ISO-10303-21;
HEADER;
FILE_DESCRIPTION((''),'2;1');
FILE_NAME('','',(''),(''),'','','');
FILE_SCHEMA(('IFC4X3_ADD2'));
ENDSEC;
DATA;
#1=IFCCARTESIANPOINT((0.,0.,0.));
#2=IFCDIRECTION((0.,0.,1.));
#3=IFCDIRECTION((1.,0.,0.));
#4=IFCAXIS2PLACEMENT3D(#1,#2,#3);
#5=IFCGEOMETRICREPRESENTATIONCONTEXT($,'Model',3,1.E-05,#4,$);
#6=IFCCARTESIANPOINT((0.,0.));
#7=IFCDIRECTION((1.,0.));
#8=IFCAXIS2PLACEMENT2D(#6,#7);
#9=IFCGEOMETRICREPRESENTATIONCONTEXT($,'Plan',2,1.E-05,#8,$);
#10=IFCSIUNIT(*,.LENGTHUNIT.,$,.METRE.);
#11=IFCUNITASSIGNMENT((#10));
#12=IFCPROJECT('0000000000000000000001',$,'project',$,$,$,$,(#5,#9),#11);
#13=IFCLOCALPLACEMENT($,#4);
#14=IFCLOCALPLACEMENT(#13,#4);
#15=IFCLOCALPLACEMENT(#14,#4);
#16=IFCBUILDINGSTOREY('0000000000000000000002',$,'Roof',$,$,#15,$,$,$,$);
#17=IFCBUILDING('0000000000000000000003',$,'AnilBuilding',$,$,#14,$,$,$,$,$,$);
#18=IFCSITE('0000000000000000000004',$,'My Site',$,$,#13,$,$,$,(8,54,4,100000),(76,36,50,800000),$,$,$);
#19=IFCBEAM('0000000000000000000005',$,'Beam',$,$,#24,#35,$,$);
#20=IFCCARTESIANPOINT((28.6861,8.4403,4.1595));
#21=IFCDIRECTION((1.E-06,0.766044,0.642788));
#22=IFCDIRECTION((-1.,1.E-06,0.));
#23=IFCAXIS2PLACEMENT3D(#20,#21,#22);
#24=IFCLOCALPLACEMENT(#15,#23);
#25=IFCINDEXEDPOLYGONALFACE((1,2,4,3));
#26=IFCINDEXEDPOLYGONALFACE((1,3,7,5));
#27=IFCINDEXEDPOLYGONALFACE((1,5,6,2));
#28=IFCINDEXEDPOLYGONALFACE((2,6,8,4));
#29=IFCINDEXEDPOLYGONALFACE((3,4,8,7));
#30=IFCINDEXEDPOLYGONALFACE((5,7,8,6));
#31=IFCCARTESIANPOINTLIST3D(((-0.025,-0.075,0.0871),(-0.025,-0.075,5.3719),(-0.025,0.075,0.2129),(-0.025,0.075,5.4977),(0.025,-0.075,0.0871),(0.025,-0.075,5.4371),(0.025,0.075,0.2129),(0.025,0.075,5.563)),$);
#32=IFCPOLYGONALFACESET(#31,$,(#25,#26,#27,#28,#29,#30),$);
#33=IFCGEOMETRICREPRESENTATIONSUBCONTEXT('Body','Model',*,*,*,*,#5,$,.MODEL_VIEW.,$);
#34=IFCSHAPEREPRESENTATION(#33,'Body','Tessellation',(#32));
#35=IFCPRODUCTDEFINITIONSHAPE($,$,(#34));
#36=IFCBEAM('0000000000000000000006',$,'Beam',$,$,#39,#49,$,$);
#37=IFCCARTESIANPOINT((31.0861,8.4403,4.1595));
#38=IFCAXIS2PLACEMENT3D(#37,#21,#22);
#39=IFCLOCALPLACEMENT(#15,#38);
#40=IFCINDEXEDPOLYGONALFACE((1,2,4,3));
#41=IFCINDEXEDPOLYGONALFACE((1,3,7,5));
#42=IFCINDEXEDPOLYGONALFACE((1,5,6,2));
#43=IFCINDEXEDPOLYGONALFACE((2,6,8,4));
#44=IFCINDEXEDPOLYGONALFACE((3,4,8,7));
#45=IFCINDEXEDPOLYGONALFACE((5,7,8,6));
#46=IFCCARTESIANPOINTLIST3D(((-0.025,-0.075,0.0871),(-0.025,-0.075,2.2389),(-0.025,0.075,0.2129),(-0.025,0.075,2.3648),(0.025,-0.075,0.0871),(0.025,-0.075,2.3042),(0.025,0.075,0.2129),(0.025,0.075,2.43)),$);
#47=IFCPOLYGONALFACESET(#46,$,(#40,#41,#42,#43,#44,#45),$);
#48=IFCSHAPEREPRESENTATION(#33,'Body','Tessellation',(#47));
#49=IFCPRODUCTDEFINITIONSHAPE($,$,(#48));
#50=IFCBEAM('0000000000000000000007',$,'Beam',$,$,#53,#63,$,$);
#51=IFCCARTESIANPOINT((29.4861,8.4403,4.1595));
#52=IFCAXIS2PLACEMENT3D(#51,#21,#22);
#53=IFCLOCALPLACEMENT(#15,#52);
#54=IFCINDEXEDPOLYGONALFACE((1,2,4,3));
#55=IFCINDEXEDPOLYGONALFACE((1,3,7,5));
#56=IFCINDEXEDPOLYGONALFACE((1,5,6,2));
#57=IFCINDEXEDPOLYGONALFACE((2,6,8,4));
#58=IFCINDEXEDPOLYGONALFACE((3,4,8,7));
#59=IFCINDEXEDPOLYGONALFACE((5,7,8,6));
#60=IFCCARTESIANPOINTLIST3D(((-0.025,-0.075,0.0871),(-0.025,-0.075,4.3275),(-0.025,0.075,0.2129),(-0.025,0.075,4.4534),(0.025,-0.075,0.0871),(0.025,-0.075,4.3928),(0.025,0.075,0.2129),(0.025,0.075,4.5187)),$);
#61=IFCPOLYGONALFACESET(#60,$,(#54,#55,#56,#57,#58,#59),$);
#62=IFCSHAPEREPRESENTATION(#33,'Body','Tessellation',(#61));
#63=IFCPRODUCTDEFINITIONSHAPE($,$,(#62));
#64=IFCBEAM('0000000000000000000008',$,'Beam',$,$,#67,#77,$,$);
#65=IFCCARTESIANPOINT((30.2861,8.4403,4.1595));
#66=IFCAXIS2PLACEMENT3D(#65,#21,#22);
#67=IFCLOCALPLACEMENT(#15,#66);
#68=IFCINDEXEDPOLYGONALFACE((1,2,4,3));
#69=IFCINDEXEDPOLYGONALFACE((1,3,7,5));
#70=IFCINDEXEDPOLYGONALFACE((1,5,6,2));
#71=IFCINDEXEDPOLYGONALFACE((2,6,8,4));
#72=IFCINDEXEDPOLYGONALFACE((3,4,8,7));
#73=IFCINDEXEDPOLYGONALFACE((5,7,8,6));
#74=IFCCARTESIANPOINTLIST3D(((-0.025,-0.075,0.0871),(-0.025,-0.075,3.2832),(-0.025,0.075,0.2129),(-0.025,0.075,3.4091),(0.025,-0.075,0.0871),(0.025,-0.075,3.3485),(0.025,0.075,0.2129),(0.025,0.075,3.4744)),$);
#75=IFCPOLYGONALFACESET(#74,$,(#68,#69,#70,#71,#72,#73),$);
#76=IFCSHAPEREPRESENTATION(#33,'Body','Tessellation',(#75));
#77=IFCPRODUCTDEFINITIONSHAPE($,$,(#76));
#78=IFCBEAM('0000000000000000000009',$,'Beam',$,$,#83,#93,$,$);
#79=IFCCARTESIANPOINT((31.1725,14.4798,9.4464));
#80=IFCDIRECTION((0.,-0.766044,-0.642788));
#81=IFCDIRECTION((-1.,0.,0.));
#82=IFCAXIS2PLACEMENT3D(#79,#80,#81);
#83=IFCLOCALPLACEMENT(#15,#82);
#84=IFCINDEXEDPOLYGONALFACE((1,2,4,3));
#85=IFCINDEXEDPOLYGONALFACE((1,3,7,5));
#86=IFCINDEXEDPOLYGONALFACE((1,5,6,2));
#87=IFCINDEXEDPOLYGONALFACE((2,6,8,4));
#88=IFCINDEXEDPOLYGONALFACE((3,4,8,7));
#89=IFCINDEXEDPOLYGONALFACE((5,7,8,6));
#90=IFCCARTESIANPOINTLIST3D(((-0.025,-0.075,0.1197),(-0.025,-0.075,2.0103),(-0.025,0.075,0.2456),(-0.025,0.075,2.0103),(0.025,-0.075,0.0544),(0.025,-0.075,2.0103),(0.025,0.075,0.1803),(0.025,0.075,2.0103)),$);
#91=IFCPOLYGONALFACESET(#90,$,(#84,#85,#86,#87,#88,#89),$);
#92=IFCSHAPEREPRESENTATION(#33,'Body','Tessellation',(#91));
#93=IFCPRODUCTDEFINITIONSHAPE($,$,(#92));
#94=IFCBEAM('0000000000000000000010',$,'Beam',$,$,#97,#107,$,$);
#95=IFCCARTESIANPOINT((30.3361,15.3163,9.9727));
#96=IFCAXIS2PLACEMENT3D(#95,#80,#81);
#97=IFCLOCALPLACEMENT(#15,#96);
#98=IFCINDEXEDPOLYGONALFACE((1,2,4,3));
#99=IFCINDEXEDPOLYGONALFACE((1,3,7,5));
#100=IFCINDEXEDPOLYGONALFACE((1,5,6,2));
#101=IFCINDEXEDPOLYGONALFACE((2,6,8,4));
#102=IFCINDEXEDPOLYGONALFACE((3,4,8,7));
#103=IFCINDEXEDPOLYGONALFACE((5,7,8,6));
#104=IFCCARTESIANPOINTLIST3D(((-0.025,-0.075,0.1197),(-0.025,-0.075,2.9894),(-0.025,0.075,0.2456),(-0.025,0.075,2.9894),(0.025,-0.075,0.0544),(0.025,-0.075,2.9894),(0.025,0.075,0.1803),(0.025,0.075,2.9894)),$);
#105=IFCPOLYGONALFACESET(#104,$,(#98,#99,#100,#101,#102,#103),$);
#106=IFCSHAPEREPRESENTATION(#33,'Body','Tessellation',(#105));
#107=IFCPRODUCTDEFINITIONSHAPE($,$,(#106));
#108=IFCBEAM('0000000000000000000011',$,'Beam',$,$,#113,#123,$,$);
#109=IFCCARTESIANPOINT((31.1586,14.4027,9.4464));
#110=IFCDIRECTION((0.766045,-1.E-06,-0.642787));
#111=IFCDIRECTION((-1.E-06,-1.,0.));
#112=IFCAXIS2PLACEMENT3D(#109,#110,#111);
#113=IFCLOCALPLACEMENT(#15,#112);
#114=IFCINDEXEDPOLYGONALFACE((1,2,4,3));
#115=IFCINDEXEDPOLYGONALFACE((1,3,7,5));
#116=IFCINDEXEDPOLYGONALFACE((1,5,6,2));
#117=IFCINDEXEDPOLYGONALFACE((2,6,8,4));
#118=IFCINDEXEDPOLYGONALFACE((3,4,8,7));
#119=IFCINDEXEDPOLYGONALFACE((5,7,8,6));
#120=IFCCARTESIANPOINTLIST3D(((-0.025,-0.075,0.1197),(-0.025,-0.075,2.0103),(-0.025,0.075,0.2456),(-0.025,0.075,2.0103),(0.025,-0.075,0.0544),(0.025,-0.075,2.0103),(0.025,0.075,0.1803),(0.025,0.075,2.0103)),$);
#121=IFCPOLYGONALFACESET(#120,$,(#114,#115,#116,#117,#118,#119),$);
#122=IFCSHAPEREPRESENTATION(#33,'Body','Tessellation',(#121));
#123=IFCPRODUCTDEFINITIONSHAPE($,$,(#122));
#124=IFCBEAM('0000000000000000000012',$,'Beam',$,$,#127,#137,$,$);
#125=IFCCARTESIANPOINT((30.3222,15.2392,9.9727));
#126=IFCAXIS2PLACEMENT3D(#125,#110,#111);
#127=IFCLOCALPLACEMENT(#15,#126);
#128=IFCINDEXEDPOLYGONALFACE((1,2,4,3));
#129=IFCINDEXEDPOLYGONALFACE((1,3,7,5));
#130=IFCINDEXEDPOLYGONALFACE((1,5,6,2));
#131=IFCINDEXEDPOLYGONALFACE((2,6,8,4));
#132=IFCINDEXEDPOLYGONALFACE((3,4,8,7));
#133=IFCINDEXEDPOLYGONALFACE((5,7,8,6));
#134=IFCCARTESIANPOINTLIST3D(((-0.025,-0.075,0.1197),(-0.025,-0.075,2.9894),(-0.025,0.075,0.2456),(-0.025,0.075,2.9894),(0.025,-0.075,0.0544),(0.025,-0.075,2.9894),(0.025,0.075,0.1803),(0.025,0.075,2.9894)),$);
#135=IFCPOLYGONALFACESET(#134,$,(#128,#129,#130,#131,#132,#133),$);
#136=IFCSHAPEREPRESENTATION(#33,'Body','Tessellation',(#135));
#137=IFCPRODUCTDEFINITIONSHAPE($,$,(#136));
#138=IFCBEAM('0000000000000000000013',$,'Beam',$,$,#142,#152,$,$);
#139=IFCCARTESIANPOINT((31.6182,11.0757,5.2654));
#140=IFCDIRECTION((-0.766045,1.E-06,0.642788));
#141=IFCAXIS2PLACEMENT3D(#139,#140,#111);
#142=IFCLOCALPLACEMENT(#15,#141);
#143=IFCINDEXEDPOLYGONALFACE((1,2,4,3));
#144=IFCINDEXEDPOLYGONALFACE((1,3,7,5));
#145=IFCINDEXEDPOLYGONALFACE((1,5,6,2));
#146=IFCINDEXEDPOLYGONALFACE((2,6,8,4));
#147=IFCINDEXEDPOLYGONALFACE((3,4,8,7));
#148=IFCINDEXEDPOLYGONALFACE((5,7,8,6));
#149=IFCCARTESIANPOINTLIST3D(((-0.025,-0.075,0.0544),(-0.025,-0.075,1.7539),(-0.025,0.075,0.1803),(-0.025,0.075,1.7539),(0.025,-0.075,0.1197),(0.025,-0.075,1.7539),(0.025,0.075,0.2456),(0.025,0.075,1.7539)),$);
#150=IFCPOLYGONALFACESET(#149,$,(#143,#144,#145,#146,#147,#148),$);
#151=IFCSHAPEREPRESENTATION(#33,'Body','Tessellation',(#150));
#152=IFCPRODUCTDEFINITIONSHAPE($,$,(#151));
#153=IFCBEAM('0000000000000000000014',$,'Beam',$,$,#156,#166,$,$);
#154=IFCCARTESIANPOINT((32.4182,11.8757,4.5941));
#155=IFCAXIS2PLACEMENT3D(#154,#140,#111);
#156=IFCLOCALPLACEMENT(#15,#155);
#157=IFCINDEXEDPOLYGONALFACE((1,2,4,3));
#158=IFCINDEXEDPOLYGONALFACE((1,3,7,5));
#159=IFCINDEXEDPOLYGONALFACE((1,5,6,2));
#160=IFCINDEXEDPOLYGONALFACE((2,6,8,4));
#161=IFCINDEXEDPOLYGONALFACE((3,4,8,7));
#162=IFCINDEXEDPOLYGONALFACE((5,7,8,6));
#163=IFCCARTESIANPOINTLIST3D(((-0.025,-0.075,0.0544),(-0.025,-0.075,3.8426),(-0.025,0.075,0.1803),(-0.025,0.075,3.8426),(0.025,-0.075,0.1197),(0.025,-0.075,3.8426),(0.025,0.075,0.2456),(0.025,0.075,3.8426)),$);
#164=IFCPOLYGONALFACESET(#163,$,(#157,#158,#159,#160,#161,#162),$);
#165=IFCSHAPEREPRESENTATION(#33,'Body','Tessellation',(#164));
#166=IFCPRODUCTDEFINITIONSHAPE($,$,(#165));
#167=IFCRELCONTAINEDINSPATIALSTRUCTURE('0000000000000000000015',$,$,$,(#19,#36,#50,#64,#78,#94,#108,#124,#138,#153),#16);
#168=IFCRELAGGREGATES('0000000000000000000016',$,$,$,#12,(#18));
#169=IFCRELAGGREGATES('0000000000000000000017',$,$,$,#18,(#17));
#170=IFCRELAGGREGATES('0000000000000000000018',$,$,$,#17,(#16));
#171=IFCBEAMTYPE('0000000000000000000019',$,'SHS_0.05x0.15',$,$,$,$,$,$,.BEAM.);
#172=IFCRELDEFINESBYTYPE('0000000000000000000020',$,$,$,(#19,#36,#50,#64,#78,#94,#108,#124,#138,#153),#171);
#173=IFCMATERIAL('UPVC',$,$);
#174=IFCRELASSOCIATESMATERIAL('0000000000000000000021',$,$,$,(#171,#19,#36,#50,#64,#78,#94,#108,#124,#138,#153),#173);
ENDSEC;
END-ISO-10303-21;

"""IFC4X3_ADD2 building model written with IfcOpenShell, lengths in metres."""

from ifc_helpers import new_model, si_unit, frame, origin_with_axes, origin_2d_with_axis, place, context, subcontext, project, spatial, indexed_curve, outline, extrude, clip, halfspace, material, material_profile, profile_set, profile_usage, type_object, element, save


model = new_model("IFC4X3_ADD2")

# Units and contexts
model_context = context("Model", 3, precision=1e-05, world=origin_with_axes())
plan_context = context("Plan", 2, precision=1e-05, world=origin_2d_with_axis())
body_context_1 = subcontext(model_context, "Body", "Model", "MODEL_VIEW")
ifc_project = project(units=[si_unit("LENGTHUNIT", "METRE")], contexts=[model_context, plan_context])

# Site, building, storey
site_placement = place(None, origin_with_axes())
site = spatial("IfcSite", under=ifc_project, at=site_placement, Name="My Site", RefLatitude=(8, 54, 4, 100000), RefLongitude=(76, 36, 50, 800000))
building_placement = place(site_placement, origin_with_axes())
building = spatial("IfcBuilding", under=site, at=building_placement, Name="AnilBuilding")
storey_placement = place(building_placement, origin_with_axes())
storey = spatial("IfcBuildingStorey", under=building, at=storey_placement, Name="Roof")

# Beams
ifc_material_1 = material(Name="UPVC")
ifc_material_profile_1 = material_profile(ifc_material_1, outline(indexed_curve([(-0.025, 0.075), (0.025, 0.075), (0.025, -0.075), (-0.025, -0.075), (-0.025, 0.075)])))
ifc_profile_set_1 = profile_set([ifc_material_profile_1])
beam_type = type_object("IfcBeamType", Name="SHS_0.05x0.15", PredefinedType="BEAM", material=ifc_profile_set_1)
ifc_profile_usage_1 = profile_usage(ifc_profile_set_1, cardinal=5)
beam_1_placement = place(storey_placement, frame((28.6861, 8.4403, 4.1595), z_axis=(0.000001, 0.766044, 0.642788), x_axis=(-1.0, 0.000001, 0.0)))
element("IfcBeam", 1, at=beam_1_placement, inside=storey, type_object=beam_type, material=ifc_profile_usage_1, Name="Beam", context=body_context_1, shape_type="Clipping", body=[
    clip(clip(extrude(outline(indexed_curve([(-0.025, 0.075), (0.025, 0.075), (0.025, -0.075), (-0.025, -0.075), (-0.025, 0.075)])), origin_with_axes(), (0.0, 0.0, 1.0), 5.6174), halfspace(frame((12.9745, -0.0793, 0.0835), z_axis=(0.0, 0.642787, -0.766045), x_axis=(1.0, -0.000001, 0.0)), False)), halfspace(frame((3.131, -0.031, 9.5286), z_axis=(-0.707106, -0.45452, 0.541676), x_axis=(-0.540717, 0.841204, 0.0)), False)),
])
ifc_profile_usage_2 = profile_usage(ifc_profile_set_1, cardinal=5)
beam_2_placement = place(storey_placement, frame((31.0861, 8.4403, 4.1595), z_axis=(0.000001, 0.766044, 0.642788), x_axis=(-1.0, 0.000001, 0.0)))
element("IfcBeam", 2, at=beam_2_placement, inside=storey, type_object=beam_type, material=ifc_profile_usage_2, Name="Beam", context=body_context_1, shape_type="Clipping", body=[
    clip(clip(extrude(outline(indexed_curve([(-0.025, 0.075), (0.025, 0.075), (0.025, -0.075), (-0.025, -0.075), (-0.025, 0.075)])), origin_with_axes(), (0.0, 0.0, 1.0), 2.4845), halfspace(frame((15.3745, -0.0793, 0.0835), z_axis=(0.0, 0.642787, -0.766045), x_axis=(1.0, -0.000001, 0.0)), False)), halfspace(frame((5.531, -0.031, 9.5286), z_axis=(-0.707106, -0.45452, 0.541676), x_axis=(-0.540717, 0.841204, 0.0)), False)),
])
ifc_profile_usage_3 = profile_usage(ifc_profile_set_1, cardinal=5)
beam_3_placement = place(storey_placement, frame((29.4861, 8.4403, 4.1595), z_axis=(0.000001, 0.766044, 0.642788), x_axis=(-1.0, 0.000001, 0.0)))
element("IfcBeam", 3, at=beam_3_placement, inside=storey, type_object=beam_type, material=ifc_profile_usage_3, Name="Beam", context=body_context_1, shape_type="Clipping", body=[
    clip(clip(extrude(outline(indexed_curve([(-0.025, 0.075), (0.025, 0.075), (0.025, -0.075), (-0.025, -0.075), (-0.025, 0.075)])), origin_with_axes(), (0.0, 0.0, 1.0), 4.5731), halfspace(frame((13.7745, -0.0793, 0.0835), z_axis=(0.0, 0.642787, -0.766045), x_axis=(1.0, -0.000001, 0.0)), False)), halfspace(frame((3.931, -0.031, 9.5286), z_axis=(-0.707106, -0.45452, 0.541676), x_axis=(-0.540717, 0.841204, 0.0)), False)),
])
ifc_profile_usage_4 = profile_usage(ifc_profile_set_1, cardinal=5)
beam_4_placement = place(storey_placement, frame((30.2861, 8.4403, 4.1595), z_axis=(0.000001, 0.766044, 0.642788), x_axis=(-1.0, 0.000001, 0.0)))
element("IfcBeam", 4, at=beam_4_placement, inside=storey, type_object=beam_type, material=ifc_profile_usage_4, Name="Beam", context=body_context_1, shape_type="Clipping", body=[
    clip(clip(extrude(outline(indexed_curve([(-0.025, 0.075), (0.025, 0.075), (0.025, -0.075), (-0.025, -0.075), (-0.025, 0.075)])), origin_with_axes(), (0.0, 0.0, 1.0), 3.5288), halfspace(frame((14.5745, -0.0793, 0.0835), z_axis=(0.0, 0.642787, -0.766045), x_axis=(1.0, -0.000001, 0.0)), False)), halfspace(frame((4.731, -0.031, 9.5286), z_axis=(-0.707106, -0.45452, 0.541676), x_axis=(-0.540717, 0.841204, 0.0)), False)),
])
ifc_profile_usage_5 = profile_usage(ifc_profile_set_1, cardinal=5)
beam_5_placement = place(storey_placement, frame((31.1725, 14.4798, 9.4464), z_axis=(0.0, -0.766044, -0.642788), x_axis=(-1.0, 0.0, 0.0)))
element("IfcBeam", 5, at=beam_5_placement, inside=storey, type_object=beam_type, material=ifc_profile_usage_5, Name="Beam", context=body_context_1, shape_type="Clipping", body=[
    clip(extrude(outline(indexed_curve([(-0.025, 0.075), (0.025, 0.075), (0.025, -0.075), (-0.025, -0.075), (-0.025, 0.075)])), origin_with_axes(), (0.0, 0.0, 1.0), 2.0103), halfspace(frame((1.3254, 0.1182, -1.4809), z_axis=(-0.707106, 0.45452, -0.541676), x_axis=(0.540717, 0.841205, 0.0)), False)),
])
ifc_profile_usage_6 = profile_usage(ifc_profile_set_1, cardinal=5)
beam_6_placement = place(storey_placement, frame((30.3361, 15.3163, 9.9727), z_axis=(0.0, -0.766044, -0.642788), x_axis=(-1.0, 0.0, 0.0)))
element("IfcBeam", 6, at=beam_6_placement, inside=storey, type_object=beam_type, material=ifc_profile_usage_6, Name="Beam", context=body_context_1, shape_type="Clipping", body=[
    clip(extrude(outline(indexed_curve([(-0.025, 0.075), (0.025, 0.075), (0.025, -0.075), (-0.025, -0.075), (-0.025, 0.075)])), origin_with_axes(), (0.0, 0.0, 1.0), 2.9894), halfspace(frame((0.4889, -0.0163, -0.5019), z_axis=(-0.707106, 0.45452, -0.541676), x_axis=(0.540717, 0.841205, 0.0)), False)),
])
ifc_profile_usage_7 = profile_usage(ifc_profile_set_1, cardinal=5)
beam_7_placement = place(storey_placement, frame((31.1586, 14.4027, 9.4464), z_axis=(0.766045, -0.000001, -0.642787), x_axis=(-0.000001, -1.0, 0.0)))
element("IfcBeam", 7, at=beam_7_placement, inside=storey, type_object=beam_type, material=ifc_profile_usage_7, Name="Beam", context=body_context_1, shape_type="Clipping", body=[
    clip(extrude(outline(indexed_curve([(-0.025, 0.075), (0.025, 0.075), (0.025, -0.075), (-0.025, -0.075), (-0.025, 0.075)])), origin_with_axes(), (0.0, 0.0, 1.0), 2.0103), halfspace(frame((1.3254, 0.1182, -1.4809), z_axis=(-0.707106, 0.45452, -0.541676), x_axis=(0.540717, 0.841205, 0.0)), False)),
])
ifc_profile_usage_8 = profile_usage(ifc_profile_set_1, cardinal=5)
beam_8_placement = place(storey_placement, frame((30.3222, 15.2392, 9.9727), z_axis=(0.766045, -0.000001, -0.642787), x_axis=(-0.000001, -1.0, 0.0)))
element("IfcBeam", 8, at=beam_8_placement, inside=storey, type_object=beam_type, material=ifc_profile_usage_8, Name="Beam", context=body_context_1, shape_type="Clipping", body=[
    clip(extrude(outline(indexed_curve([(-0.025, 0.075), (0.025, 0.075), (0.025, -0.075), (-0.025, -0.075), (-0.025, 0.075)])), origin_with_axes(), (0.0, 0.0, 1.0), 2.9894), halfspace(frame((0.4889, -0.0163, -0.5019), z_axis=(-0.707106, 0.45452, -0.541676), x_axis=(0.540717, 0.841205, 0.0)), False)),
])
ifc_profile_usage_9 = profile_usage(ifc_profile_set_1, cardinal=5)
beam_9_placement = place(storey_placement, frame((31.6182, 11.0757, 5.2654), z_axis=(-0.766045, 0.000001, 0.642788), x_axis=(-0.000001, -1.0, 0.0)))
element("IfcBeam", 9, at=beam_9_placement, inside=storey, type_object=beam_type, material=ifc_profile_usage_9, Name="Beam", context=body_context_1, shape_type="Clipping", body=[
    clip(extrude(outline(indexed_curve([(-0.025, 0.075), (0.025, 0.075), (0.025, -0.075), (-0.025, -0.075), (-0.025, 0.075)])), origin_with_axes(), (0.0, 0.0, 1.0), 1.7539), halfspace(frame((0.5527, 0.0835, 0.9416), z_axis=(0.707105, 0.45452, -0.541676), x_axis=(0.540718, -0.841204, 0.0)), False)),
])
ifc_profile_usage_10 = profile_usage(ifc_profile_set_1, cardinal=5)
beam_10_placement = place(storey_placement, frame((32.4182, 11.8757, 4.5941), z_axis=(-0.766045, 0.000001, 0.642788), x_axis=(-0.000001, -1.0, 0.0)))
element("IfcBeam", 10, at=beam_10_placement, inside=storey, type_object=beam_type, material=ifc_profile_usage_10, Name="Beam", context=body_context_1, shape_type="Clipping", body=[
    clip(extrude(outline(indexed_curve([(-0.025, 0.075), (0.025, 0.075), (0.025, -0.075), (-0.025, -0.075), (-0.025, 0.075)])), origin_with_axes(), (0.0, 0.0, 1.0), 3.8426), halfspace(frame((1.3527, 0.0835, 1.9859), z_axis=(0.707105, 0.45452, -0.541676), x_axis=(0.540718, -0.841204, 0.0)), False)),
])

save(model, "model.ifc")
